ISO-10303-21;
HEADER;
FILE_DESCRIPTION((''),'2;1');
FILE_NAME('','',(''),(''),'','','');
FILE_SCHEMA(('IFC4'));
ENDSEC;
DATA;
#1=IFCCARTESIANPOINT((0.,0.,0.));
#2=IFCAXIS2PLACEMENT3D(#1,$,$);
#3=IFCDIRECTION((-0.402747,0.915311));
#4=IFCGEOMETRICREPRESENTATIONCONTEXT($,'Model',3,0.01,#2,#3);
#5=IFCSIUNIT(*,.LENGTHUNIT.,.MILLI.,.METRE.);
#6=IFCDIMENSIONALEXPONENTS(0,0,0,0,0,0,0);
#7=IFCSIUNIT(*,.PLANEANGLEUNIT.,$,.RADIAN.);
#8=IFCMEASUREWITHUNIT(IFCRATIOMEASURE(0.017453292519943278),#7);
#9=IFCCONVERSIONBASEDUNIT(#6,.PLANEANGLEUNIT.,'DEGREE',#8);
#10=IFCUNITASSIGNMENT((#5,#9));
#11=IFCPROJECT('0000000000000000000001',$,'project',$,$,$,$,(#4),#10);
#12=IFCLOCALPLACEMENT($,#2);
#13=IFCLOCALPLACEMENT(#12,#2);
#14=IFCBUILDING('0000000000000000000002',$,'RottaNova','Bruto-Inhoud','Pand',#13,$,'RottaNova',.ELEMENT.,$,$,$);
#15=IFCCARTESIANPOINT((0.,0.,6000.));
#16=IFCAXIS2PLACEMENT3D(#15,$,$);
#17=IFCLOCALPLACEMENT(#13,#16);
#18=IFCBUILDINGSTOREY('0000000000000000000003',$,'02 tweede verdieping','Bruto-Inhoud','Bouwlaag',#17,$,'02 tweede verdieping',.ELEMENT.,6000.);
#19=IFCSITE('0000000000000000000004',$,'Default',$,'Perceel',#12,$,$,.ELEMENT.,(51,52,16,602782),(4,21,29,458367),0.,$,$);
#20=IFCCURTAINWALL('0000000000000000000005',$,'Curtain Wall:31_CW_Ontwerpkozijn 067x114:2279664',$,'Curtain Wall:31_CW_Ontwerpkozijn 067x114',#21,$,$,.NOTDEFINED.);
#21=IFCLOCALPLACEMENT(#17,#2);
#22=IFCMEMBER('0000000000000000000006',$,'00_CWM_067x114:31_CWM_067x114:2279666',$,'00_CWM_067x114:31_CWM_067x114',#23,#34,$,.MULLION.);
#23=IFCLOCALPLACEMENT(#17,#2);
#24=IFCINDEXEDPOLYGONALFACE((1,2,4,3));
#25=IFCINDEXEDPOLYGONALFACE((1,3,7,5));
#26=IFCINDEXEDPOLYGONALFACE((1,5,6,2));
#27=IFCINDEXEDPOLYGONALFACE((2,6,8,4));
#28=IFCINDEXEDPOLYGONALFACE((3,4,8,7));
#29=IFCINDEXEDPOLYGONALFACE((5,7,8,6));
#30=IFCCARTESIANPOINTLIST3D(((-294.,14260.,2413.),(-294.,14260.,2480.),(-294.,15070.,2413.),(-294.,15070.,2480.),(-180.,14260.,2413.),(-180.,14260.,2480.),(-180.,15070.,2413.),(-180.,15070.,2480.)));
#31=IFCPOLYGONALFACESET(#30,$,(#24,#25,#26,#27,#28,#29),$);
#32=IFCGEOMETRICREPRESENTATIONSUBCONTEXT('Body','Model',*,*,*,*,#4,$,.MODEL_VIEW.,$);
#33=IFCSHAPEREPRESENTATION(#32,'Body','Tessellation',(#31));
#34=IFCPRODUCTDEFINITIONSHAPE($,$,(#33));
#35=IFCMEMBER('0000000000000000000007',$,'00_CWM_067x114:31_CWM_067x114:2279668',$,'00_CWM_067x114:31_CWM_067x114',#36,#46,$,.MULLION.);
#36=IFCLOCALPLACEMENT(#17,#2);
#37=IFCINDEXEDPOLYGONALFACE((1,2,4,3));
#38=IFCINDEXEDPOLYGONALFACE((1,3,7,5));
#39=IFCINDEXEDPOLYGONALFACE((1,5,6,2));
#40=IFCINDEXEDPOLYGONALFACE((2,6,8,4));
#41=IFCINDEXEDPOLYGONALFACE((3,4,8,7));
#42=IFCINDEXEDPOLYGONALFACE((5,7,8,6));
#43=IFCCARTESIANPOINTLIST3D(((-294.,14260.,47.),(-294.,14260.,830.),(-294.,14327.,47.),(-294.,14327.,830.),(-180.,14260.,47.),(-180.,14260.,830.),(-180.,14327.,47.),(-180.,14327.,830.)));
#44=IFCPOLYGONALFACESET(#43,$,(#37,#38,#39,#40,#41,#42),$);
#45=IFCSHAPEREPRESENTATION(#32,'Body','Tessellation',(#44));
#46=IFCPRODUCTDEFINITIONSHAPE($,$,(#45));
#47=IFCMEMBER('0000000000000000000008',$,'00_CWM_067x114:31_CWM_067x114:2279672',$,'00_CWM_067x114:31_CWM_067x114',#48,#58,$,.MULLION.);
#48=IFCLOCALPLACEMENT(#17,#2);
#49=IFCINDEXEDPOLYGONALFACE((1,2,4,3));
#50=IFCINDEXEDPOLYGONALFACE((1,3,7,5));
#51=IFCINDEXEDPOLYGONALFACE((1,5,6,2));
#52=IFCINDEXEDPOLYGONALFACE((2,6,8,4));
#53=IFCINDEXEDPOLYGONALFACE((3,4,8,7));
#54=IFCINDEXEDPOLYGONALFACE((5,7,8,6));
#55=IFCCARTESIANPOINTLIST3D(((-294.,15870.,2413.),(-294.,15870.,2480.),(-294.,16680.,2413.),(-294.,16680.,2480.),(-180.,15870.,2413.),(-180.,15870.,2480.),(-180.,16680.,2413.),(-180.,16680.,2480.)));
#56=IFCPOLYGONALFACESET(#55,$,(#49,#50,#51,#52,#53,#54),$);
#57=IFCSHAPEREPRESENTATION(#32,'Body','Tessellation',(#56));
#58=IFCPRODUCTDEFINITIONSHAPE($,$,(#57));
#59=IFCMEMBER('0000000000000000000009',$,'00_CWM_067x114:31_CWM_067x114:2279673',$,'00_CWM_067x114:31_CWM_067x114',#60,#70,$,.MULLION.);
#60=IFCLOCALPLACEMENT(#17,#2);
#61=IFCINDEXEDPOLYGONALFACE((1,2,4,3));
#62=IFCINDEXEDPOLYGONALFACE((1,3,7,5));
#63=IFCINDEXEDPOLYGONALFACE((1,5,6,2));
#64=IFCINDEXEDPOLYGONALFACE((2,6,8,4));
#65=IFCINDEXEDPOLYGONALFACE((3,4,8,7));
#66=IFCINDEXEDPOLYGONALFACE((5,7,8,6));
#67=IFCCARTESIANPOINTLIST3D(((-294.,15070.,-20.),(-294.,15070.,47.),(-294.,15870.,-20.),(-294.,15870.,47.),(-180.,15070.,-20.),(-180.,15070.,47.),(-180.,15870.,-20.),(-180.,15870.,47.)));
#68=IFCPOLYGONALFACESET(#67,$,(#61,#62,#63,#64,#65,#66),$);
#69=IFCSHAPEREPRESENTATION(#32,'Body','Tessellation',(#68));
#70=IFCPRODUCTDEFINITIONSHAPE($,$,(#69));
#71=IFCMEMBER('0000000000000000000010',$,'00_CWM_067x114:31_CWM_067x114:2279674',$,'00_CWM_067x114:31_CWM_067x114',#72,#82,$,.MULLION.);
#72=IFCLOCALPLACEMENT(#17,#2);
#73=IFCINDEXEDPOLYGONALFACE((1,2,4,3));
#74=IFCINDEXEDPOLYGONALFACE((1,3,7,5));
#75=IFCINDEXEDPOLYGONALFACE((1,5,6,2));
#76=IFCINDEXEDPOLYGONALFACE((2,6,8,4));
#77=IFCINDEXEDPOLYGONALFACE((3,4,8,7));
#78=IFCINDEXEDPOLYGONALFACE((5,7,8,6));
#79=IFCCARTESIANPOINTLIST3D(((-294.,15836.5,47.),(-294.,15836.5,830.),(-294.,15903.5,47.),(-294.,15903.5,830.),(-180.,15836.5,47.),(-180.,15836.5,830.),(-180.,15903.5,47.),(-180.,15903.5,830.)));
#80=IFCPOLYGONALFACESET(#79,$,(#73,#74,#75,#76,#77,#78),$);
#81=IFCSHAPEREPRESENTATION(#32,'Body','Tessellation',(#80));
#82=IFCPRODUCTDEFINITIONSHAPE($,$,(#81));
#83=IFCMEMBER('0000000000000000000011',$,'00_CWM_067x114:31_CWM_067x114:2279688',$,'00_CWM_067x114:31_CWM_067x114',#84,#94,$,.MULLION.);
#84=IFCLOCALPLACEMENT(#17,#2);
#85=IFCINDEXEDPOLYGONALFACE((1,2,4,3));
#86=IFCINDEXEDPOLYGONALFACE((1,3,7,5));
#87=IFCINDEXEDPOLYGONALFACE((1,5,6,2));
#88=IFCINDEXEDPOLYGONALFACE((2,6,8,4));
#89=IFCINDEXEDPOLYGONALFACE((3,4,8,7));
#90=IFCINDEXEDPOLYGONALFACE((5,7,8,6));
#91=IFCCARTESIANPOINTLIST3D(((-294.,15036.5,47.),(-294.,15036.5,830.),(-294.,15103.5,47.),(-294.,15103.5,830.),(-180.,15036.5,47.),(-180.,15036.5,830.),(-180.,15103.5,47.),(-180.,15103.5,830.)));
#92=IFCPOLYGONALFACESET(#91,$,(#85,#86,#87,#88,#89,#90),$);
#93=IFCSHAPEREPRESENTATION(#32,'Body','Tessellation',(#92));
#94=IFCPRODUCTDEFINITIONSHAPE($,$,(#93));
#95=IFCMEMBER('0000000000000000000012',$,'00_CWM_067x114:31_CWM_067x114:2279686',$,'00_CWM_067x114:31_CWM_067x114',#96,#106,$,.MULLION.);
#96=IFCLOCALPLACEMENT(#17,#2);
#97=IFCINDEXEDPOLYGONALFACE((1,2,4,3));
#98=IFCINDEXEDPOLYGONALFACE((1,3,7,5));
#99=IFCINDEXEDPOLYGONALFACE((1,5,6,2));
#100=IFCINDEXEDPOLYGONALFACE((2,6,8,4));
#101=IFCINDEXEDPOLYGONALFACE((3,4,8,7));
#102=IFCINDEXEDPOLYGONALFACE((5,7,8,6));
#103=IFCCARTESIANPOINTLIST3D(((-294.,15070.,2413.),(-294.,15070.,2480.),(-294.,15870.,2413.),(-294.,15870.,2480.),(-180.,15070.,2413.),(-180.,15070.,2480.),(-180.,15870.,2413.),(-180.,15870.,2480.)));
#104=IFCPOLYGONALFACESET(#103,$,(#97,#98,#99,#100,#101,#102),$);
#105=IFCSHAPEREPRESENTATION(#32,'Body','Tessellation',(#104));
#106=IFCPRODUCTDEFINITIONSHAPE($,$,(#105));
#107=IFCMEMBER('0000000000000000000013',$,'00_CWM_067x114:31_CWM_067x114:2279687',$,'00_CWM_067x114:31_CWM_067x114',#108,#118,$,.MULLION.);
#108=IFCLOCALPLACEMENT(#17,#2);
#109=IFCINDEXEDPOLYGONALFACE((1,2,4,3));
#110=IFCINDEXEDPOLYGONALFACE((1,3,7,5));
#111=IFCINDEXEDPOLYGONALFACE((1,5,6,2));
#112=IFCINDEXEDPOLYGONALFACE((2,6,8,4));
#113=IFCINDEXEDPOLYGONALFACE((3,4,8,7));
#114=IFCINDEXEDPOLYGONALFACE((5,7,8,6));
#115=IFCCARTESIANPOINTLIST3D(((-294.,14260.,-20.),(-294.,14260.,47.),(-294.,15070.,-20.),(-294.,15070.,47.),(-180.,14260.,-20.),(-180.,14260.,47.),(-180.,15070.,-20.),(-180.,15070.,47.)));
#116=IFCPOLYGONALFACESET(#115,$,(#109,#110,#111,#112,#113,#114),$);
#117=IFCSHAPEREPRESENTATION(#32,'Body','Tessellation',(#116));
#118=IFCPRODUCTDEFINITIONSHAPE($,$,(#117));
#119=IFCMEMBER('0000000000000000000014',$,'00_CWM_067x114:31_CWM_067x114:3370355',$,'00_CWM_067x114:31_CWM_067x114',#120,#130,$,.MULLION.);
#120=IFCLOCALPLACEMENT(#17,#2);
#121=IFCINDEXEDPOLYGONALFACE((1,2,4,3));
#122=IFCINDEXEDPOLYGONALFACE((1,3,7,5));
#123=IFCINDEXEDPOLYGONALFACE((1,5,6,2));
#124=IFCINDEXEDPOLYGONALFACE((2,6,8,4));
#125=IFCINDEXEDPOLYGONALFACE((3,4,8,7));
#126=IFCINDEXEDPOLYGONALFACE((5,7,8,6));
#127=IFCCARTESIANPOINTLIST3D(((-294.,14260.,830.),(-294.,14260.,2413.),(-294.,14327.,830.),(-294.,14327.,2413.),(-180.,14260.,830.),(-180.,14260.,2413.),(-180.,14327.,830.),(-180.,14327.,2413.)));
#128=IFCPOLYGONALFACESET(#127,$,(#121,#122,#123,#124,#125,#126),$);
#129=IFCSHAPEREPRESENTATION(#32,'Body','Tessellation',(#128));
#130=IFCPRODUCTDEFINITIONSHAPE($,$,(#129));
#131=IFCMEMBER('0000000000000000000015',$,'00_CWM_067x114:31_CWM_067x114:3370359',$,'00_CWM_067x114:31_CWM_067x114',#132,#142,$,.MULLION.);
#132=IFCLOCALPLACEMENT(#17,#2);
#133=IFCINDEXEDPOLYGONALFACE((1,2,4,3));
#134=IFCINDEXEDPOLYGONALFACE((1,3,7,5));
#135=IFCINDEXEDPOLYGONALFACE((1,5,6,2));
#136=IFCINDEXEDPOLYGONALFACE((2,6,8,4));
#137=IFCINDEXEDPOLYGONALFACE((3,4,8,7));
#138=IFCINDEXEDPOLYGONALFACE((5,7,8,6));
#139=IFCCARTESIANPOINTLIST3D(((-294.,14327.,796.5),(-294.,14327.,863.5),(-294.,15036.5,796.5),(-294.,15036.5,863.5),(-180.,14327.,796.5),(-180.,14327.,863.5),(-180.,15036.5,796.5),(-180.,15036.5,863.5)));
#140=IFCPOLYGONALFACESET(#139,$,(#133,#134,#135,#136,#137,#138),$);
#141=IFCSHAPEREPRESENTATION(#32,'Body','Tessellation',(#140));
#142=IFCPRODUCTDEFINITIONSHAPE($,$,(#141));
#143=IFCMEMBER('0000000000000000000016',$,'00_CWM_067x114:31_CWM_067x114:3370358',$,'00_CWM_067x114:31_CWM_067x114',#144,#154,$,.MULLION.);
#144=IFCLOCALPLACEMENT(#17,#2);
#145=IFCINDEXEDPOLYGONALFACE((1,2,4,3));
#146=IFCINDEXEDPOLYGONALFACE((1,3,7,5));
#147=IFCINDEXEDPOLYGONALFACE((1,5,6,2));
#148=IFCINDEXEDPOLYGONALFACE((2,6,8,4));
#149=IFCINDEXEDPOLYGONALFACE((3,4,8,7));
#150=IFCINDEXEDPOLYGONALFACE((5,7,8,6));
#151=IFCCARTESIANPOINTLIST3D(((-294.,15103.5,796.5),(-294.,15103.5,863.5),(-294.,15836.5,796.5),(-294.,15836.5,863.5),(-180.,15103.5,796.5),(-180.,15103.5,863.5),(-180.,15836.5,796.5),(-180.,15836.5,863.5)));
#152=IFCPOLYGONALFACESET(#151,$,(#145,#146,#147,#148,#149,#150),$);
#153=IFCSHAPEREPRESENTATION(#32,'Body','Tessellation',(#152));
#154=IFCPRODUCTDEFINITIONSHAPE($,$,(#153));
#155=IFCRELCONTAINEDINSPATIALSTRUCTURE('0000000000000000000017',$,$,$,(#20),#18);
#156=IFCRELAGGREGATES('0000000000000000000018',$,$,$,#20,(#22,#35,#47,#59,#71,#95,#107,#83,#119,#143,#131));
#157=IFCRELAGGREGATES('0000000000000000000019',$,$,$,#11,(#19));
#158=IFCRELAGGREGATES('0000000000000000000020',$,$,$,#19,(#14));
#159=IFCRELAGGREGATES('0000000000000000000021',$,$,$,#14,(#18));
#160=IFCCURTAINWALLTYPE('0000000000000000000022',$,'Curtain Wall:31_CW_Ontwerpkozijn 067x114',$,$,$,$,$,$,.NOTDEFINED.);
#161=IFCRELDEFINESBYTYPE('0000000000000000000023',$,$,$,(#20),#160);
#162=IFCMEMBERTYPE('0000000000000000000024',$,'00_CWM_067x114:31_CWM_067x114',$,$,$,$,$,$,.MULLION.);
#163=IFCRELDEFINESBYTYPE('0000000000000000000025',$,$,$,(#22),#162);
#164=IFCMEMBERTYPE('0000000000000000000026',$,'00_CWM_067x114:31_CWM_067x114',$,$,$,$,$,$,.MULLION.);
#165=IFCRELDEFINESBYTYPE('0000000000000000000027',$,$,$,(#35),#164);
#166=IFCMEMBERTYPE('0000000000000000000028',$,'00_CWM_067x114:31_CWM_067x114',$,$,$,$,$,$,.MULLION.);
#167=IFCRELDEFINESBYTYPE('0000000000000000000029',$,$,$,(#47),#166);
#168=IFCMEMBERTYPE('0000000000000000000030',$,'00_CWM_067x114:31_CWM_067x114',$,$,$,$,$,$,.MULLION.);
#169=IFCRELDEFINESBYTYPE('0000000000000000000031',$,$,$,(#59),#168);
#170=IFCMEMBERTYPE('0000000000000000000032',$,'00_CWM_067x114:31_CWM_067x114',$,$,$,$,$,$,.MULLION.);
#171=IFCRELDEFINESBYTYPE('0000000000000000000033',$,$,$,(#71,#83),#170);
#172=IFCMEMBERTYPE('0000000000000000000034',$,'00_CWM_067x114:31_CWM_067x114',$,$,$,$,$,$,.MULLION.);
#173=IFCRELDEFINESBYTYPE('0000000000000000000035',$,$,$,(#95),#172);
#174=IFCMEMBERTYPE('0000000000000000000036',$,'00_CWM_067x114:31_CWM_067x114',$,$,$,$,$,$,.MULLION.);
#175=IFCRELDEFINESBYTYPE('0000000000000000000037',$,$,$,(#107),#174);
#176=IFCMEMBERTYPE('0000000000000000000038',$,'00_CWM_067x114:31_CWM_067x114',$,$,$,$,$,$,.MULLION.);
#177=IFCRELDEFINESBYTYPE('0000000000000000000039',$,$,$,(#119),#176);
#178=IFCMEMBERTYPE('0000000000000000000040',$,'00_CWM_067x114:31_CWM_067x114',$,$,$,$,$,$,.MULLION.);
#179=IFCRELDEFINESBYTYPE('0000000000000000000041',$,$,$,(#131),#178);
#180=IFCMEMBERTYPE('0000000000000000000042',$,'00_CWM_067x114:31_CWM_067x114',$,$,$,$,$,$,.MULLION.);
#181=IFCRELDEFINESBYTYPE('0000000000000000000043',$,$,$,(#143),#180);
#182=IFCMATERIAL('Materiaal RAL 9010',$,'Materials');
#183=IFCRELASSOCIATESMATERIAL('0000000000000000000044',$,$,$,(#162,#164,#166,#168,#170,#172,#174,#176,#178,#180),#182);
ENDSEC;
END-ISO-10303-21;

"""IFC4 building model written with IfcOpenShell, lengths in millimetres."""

from ifc_helpers import new_model, entity, si_unit, converted_unit, direction, frame, origin, origin_2d_with_axis, place, context, subcontext, project, spatial, rectangle, extrude, source, transform, mapped, material, material_profile, profile_set, type_object, type_shapes, element, aggregate, save


model = new_model("IFC4")

# Units and contexts
model_context = context("Model", 3, precision=0.01, world=origin(), true_north=direction((-0.402747, 0.915311)))
body_context = subcontext(model_context, "Body", "Model", "MODEL_VIEW")
ifc_project = project(units=[si_unit("LENGTHUNIT", "METRE", prefix="MILLI"), converted_unit("PLANEANGLEUNIT", "DEGREE", entity("IfcRatioMeasure", 0.017453292519943278), si_unit("PLANEANGLEUNIT", "RADIAN"), dimensions=[0, 0, 0, 0, 0, 0, 0])], contexts=[model_context])

# Site, building, storey
site_placement = place(None, origin())
site = spatial("IfcSite", under=ifc_project, at=site_placement, Name="Default", ObjectType="Perceel", CompositionType="ELEMENT", RefLatitude=(51, 52, 16, 602782), RefLongitude=(4, 21, 29, 458367), RefElevation=0.0)
building_placement = place(site_placement, origin())
building = spatial("IfcBuilding", under=site, at=building_placement, Name="RottaNova", Description="Bruto-Inhoud", ObjectType="Pand", LongName="RottaNova", CompositionType="ELEMENT")
storey_placement = place(building_placement, frame((0.0, 0.0, 6000.0)))
storey = spatial("IfcBuildingStorey", under=building, at=storey_placement, Name="02 tweede verdieping", Description="Bruto-Inhoud", ObjectType="Bouwlaag", LongName="02 tweede verdieping", CompositionType="ELEMENT", Elevation=6000.0)

# Curtain wall, members
curtain_wall_type = type_object("IfcCurtainWallType", Name="Curtain Wall:31_CW_Ontwerpkozijn 067x114", PredefinedType="NOTDEFINED")
curtain_wall_placement = place(storey_placement, frame((0.0, 0.0, -6000.0)))
curtain_wall = element("IfcCurtainWall", 1, at=curtain_wall_placement, inside=storey, type_object=curtain_wall_type, Name="Curtain Wall:31_CW_Ontwerpkozijn 067x114:2279664", ObjectType="Curtain Wall:31_CW_Ontwerpkozijn 067x114", PredefinedType="NOTDEFINED")
ifc_material_1 = material(Name="Materiaal RAL 9010", Category="Materials")
ifc_material_profile = material_profile(ifc_material_1, rectangle(XDim=114.0, YDim=67.0, at=origin_2d_with_axis()), Name="31_CWM_067x114")
ifc_profile_set = profile_set([ifc_material_profile], Name="31_CWM_067x114")
member_type_1 = type_object("IfcMemberType", Name="00_CWM_067x114:31_CWM_067x114", PredefinedType="MULLION", material=ifc_profile_set)
shared_shape_1 = source(origin(), body_context, "Body", "SweptSolid", [
    extrude(rectangle(XDim=114.0, YDim=67.0, at=origin_2d_with_axis()), frame((-33.5, 57.0, -810.0), z_axis=(0.0, 0.0, 1.0), x_axis=(0.0, -1.0, 0.0)), (0.0, 0.0, 1.0), 810.0),
])
type_shapes(member_type_1, [shared_shape_1])
member_1_placement = place(curtain_wall_placement, frame((-180.0, 14260.0, 8480.0), z_axis=(0.0, -1.0, 0.0), x_axis=(0.0, 0.0, 1.0)))
member_1 = element("IfcMember", 2, at=member_1_placement, type_object=member_type_1, Name="00_CWM_067x114:31_CWM_067x114:2279666", ObjectType="00_CWM_067x114:31_CWM_067x114", PredefinedType="MULLION", context=body_context, shape_type="MappedRepresentation", body=[
    mapped(shared_shape_1, transform((0.0, 0.0, 0.0), scale=1.0)),
])
member_type_2 = type_object("IfcMemberType", Name="00_CWM_067x114:31_CWM_067x114", PredefinedType="MULLION", material=ifc_profile_set)
shared_shape_2 = source(origin(), body_context, "Body", "SweptSolid", [
    extrude(rectangle(XDim=114.0, YDim=67.0, at=origin_2d_with_axis()), frame((-33.5, 57.0, -783.0), z_axis=(0.0, 0.0, 1.0), x_axis=(0.0, -1.0, 0.0)), (0.0, 0.0, 1.0), 783.0),
])
type_shapes(member_type_2, [shared_shape_2])
member_2_placement = place(curtain_wall_placement, frame((-180.0, 14260.0, 6047.0), z_axis=(0.0, 0.0, -1.0), x_axis=(0.0, -1.0, 0.0)))
member_2 = element("IfcMember", 3, at=member_2_placement, type_object=member_type_2, Name="00_CWM_067x114:31_CWM_067x114:2279668", ObjectType="00_CWM_067x114:31_CWM_067x114", PredefinedType="MULLION", context=body_context, shape_type="MappedRepresentation", body=[
    mapped(shared_shape_2, transform((0.0, 0.0, 0.0), scale=1.0)),
])
member_type_3 = type_object("IfcMemberType", Name="00_CWM_067x114:31_CWM_067x114", PredefinedType="MULLION", material=ifc_profile_set)
shared_shape_3 = source(origin(), body_context, "Body", "SweptSolid", [
    extrude(rectangle(XDim=114.0, YDim=67.0, at=origin_2d_with_axis()), frame((-33.5, 57.0, -810.0), z_axis=(0.0, 0.0, 1.0), x_axis=(0.0, -1.0, 0.0)), (0.0, 0.0, 1.0), 810.0),
])
type_shapes(member_type_3, [shared_shape_3])
member_3_placement = place(curtain_wall_placement, frame((-180.0, 15870.0, 8480.0), z_axis=(0.0, -1.0, 0.0), x_axis=(0.0, 0.0, 1.0)))
member_3 = element("IfcMember", 4, at=member_3_placement, type_object=member_type_3, Name="00_CWM_067x114:31_CWM_067x114:2279672", ObjectType="00_CWM_067x114:31_CWM_067x114", PredefinedType="MULLION", context=body_context, shape_type="MappedRepresentation", body=[
    mapped(shared_shape_3, transform((0.0, 0.0, 0.0), scale=1.0)),
])
member_type_4 = type_object("IfcMemberType", Name="00_CWM_067x114:31_CWM_067x114", PredefinedType="MULLION", material=ifc_profile_set)
shared_shape_4 = source(origin(), body_context, "Body", "SweptSolid", [
    extrude(rectangle(XDim=114.0, YDim=67.0, at=origin_2d_with_axis()), frame((-33.5, 57.0, -800.0), z_axis=(0.0, 0.0, 1.0), x_axis=(0.0, -1.0, 0.0)), (0.0, 0.0, 1.0), 800.0),
])
type_shapes(member_type_4, [shared_shape_4])
member_4_placement = place(curtain_wall_placement, frame((-180.0, 15870.0, 5980.0), z_axis=(0.0, 1.0, 0.0), x_axis=(0.0, 0.0, -1.0)))
member_4 = element("IfcMember", 5, at=member_4_placement, type_object=member_type_4, Name="00_CWM_067x114:31_CWM_067x114:2279673", ObjectType="00_CWM_067x114:31_CWM_067x114", PredefinedType="MULLION", context=body_context, shape_type="MappedRepresentation", body=[
    mapped(shared_shape_4, transform((0.0, 0.0, 0.0), scale=1.0)),
])
member_type_5 = type_object("IfcMemberType", Name="00_CWM_067x114:31_CWM_067x114", PredefinedType="MULLION", material=ifc_profile_set)
shared_shape_5 = source(origin(), body_context, "Body", "SweptSolid", [
    extrude(rectangle(XDim=114.0, YDim=67.0, at=origin_2d_with_axis()), frame((0.0, 57.0, -783.0), z_axis=(0.0, 0.0, 1.0), x_axis=(0.0, -1.0, 0.0)), (0.0, 0.0, 1.0), 783.0),
])
type_shapes(member_type_5, [shared_shape_5])
member_5_placement = place(curtain_wall_placement, frame((-180.0, 15870.0, 6047.0), z_axis=(0.0, 0.0, -1.0), x_axis=(0.0, -1.0, 0.0)))
member_5 = element("IfcMember", 6, at=member_5_placement, type_object=member_type_5, Name="00_CWM_067x114:31_CWM_067x114:2279674", ObjectType="00_CWM_067x114:31_CWM_067x114", PredefinedType="MULLION", context=body_context, shape_type="MappedRepresentation", body=[
    mapped(shared_shape_5, transform((0.0, 0.0, 0.0), scale=1.0)),
])
member_6_placement = place(curtain_wall_placement, frame((-180.0, 15070.0, 6047.0), z_axis=(0.0, 0.0, -1.0), x_axis=(0.0, -1.0, 0.0)))
member_6 = element("IfcMember", 7, at=member_6_placement, type_object=member_type_5, Name="00_CWM_067x114:31_CWM_067x114:2279688", ObjectType="00_CWM_067x114:31_CWM_067x114", PredefinedType="MULLION", context=body_context, shape_type="MappedRepresentation", body=[
    mapped(shared_shape_5, transform((0.0, 0.0, 0.0), scale=1.0)),
])
member_type_6 = type_object("IfcMemberType", Name="00_CWM_067x114:31_CWM_067x114", PredefinedType="MULLION", material=ifc_profile_set)
shared_shape_6 = source(origin(), body_context, "Body", "SweptSolid", [
    extrude(rectangle(XDim=114.0, YDim=67.0, at=origin_2d_with_axis()), frame((-33.5, 57.0, -800.0), z_axis=(0.0, 0.0, 1.0), x_axis=(0.0, -1.0, 0.0)), (0.0, 0.0, 1.0), 800.0),
])
type_shapes(member_type_6, [shared_shape_6])
member_7_placement = place(curtain_wall_placement, frame((-180.0, 15070.0, 8480.0), z_axis=(0.0, -1.0, 0.0), x_axis=(0.0, 0.0, 1.0)))
member_7 = element("IfcMember", 8, at=member_7_placement, type_object=member_type_6, Name="00_CWM_067x114:31_CWM_067x114:2279686", ObjectType="00_CWM_067x114:31_CWM_067x114", PredefinedType="MULLION", context=body_context, shape_type="MappedRepresentation", body=[
    mapped(shared_shape_6, transform((0.0, 0.0, 0.0), scale=1.0)),
])
member_type_7 = type_object("IfcMemberType", Name="00_CWM_067x114:31_CWM_067x114", PredefinedType="MULLION", material=ifc_profile_set)
shared_shape_7 = source(origin(), body_context, "Body", "SweptSolid", [
    extrude(rectangle(XDim=114.0, YDim=67.0, at=origin_2d_with_axis()), frame((-33.5, 57.0, -810.0), z_axis=(0.0, 0.0, 1.0), x_axis=(0.0, -1.0, 0.0)), (0.0, 0.0, 1.0), 810.0),
])
type_shapes(member_type_7, [shared_shape_7])
member_8_placement = place(curtain_wall_placement, frame((-180.0, 15070.0, 5980.0), z_axis=(0.0, 1.0, 0.0), x_axis=(0.0, 0.0, -1.0)))
member_8 = element("IfcMember", 9, at=member_8_placement, type_object=member_type_7, Name="00_CWM_067x114:31_CWM_067x114:2279687", ObjectType="00_CWM_067x114:31_CWM_067x114", PredefinedType="MULLION", context=body_context, shape_type="MappedRepresentation", body=[
    mapped(shared_shape_7, transform((0.0, 0.0, 0.0), scale=1.0)),
])
member_type_8 = type_object("IfcMemberType", Name="00_CWM_067x114:31_CWM_067x114", PredefinedType="MULLION", material=ifc_profile_set)
shared_shape_8 = source(origin(), body_context, "Body", "SweptSolid", [
    extrude(rectangle(XDim=114.0, YDim=67.0, at=origin_2d_with_axis()), frame((-33.5, 57.0, -1583.0), z_axis=(0.0, 0.0, 1.0), x_axis=(0.0, -1.0, 0.0)), (0.0, 0.0, 1.0), 1583.0),
])
type_shapes(member_type_8, [shared_shape_8])
member_9_placement = place(curtain_wall_placement, frame((-180.0, 14260.0, 6830.0), z_axis=(0.0, 0.0, -1.0), x_axis=(0.0, -1.0, 0.0)))
member_9 = element("IfcMember", 10, at=member_9_placement, type_object=member_type_8, Name="00_CWM_067x114:31_CWM_067x114:3370355", ObjectType="00_CWM_067x114:31_CWM_067x114", PredefinedType="MULLION", context=body_context, shape_type="MappedRepresentation", body=[
    mapped(shared_shape_8, transform((0.0, 0.0, 0.0), scale=1.0)),
])
member_type_9 = type_object("IfcMemberType", Name="00_CWM_067x114:31_CWM_067x114", PredefinedType="MULLION", material=ifc_profile_set)
shared_shape_9 = source(origin(), body_context, "Body", "SweptSolid", [
    extrude(rectangle(XDim=114.0, YDim=67.0, at=origin_2d_with_axis()), frame((0.0, 57.0, -709.5), z_axis=(0.0, 0.0, 1.0), x_axis=(0.0, -1.0, 0.0)), (0.0, 0.0, 1.0), 709.5),
])
type_shapes(member_type_9, [shared_shape_9])
member_10_placement = place(curtain_wall_placement, frame((-180.0, 14327.0, 6830.0), z_axis=(0.0, -1.0, 0.0), x_axis=(0.0, 0.0, 1.0)))
member_10 = element("IfcMember", 11, at=member_10_placement, type_object=member_type_9, Name="00_CWM_067x114:31_CWM_067x114:3370359", ObjectType="00_CWM_067x114:31_CWM_067x114", PredefinedType="MULLION", context=body_context, shape_type="MappedRepresentation", body=[
    mapped(shared_shape_9, transform((0.0, 0.0, 0.0), scale=1.0)),
])
member_type_10 = type_object("IfcMemberType", Name="00_CWM_067x114:31_CWM_067x114", PredefinedType="MULLION", material=ifc_profile_set)
shared_shape_10 = source(origin(), body_context, "Body", "SweptSolid", [
    extrude(rectangle(XDim=114.0, YDim=67.0, at=origin_2d_with_axis()), frame((0.0, 57.0, -733.0), z_axis=(0.0, 0.0, 1.0), x_axis=(0.0, -1.0, 0.0)), (0.0, 0.0, 1.0), 733.0),
])
type_shapes(member_type_10, [shared_shape_10])
member_11_placement = place(curtain_wall_placement, frame((-180.0, 15103.5, 6830.0), z_axis=(0.0, -1.0, 0.0), x_axis=(0.0, 0.0, 1.0)))
member_11 = element("IfcMember", 12, at=member_11_placement, type_object=member_type_10, Name="00_CWM_067x114:31_CWM_067x114:3370358", ObjectType="00_CWM_067x114:31_CWM_067x114", PredefinedType="MULLION", context=body_context, shape_type="MappedRepresentation", body=[
    mapped(shared_shape_10, transform((0.0, 0.0, 0.0), scale=1.0)),
])

aggregate(curtain_wall, [member_1, member_2, member_3, member_4, member_5, member_7, member_8, member_6, member_9, member_11, member_10])

save(model, "model.ifc")
